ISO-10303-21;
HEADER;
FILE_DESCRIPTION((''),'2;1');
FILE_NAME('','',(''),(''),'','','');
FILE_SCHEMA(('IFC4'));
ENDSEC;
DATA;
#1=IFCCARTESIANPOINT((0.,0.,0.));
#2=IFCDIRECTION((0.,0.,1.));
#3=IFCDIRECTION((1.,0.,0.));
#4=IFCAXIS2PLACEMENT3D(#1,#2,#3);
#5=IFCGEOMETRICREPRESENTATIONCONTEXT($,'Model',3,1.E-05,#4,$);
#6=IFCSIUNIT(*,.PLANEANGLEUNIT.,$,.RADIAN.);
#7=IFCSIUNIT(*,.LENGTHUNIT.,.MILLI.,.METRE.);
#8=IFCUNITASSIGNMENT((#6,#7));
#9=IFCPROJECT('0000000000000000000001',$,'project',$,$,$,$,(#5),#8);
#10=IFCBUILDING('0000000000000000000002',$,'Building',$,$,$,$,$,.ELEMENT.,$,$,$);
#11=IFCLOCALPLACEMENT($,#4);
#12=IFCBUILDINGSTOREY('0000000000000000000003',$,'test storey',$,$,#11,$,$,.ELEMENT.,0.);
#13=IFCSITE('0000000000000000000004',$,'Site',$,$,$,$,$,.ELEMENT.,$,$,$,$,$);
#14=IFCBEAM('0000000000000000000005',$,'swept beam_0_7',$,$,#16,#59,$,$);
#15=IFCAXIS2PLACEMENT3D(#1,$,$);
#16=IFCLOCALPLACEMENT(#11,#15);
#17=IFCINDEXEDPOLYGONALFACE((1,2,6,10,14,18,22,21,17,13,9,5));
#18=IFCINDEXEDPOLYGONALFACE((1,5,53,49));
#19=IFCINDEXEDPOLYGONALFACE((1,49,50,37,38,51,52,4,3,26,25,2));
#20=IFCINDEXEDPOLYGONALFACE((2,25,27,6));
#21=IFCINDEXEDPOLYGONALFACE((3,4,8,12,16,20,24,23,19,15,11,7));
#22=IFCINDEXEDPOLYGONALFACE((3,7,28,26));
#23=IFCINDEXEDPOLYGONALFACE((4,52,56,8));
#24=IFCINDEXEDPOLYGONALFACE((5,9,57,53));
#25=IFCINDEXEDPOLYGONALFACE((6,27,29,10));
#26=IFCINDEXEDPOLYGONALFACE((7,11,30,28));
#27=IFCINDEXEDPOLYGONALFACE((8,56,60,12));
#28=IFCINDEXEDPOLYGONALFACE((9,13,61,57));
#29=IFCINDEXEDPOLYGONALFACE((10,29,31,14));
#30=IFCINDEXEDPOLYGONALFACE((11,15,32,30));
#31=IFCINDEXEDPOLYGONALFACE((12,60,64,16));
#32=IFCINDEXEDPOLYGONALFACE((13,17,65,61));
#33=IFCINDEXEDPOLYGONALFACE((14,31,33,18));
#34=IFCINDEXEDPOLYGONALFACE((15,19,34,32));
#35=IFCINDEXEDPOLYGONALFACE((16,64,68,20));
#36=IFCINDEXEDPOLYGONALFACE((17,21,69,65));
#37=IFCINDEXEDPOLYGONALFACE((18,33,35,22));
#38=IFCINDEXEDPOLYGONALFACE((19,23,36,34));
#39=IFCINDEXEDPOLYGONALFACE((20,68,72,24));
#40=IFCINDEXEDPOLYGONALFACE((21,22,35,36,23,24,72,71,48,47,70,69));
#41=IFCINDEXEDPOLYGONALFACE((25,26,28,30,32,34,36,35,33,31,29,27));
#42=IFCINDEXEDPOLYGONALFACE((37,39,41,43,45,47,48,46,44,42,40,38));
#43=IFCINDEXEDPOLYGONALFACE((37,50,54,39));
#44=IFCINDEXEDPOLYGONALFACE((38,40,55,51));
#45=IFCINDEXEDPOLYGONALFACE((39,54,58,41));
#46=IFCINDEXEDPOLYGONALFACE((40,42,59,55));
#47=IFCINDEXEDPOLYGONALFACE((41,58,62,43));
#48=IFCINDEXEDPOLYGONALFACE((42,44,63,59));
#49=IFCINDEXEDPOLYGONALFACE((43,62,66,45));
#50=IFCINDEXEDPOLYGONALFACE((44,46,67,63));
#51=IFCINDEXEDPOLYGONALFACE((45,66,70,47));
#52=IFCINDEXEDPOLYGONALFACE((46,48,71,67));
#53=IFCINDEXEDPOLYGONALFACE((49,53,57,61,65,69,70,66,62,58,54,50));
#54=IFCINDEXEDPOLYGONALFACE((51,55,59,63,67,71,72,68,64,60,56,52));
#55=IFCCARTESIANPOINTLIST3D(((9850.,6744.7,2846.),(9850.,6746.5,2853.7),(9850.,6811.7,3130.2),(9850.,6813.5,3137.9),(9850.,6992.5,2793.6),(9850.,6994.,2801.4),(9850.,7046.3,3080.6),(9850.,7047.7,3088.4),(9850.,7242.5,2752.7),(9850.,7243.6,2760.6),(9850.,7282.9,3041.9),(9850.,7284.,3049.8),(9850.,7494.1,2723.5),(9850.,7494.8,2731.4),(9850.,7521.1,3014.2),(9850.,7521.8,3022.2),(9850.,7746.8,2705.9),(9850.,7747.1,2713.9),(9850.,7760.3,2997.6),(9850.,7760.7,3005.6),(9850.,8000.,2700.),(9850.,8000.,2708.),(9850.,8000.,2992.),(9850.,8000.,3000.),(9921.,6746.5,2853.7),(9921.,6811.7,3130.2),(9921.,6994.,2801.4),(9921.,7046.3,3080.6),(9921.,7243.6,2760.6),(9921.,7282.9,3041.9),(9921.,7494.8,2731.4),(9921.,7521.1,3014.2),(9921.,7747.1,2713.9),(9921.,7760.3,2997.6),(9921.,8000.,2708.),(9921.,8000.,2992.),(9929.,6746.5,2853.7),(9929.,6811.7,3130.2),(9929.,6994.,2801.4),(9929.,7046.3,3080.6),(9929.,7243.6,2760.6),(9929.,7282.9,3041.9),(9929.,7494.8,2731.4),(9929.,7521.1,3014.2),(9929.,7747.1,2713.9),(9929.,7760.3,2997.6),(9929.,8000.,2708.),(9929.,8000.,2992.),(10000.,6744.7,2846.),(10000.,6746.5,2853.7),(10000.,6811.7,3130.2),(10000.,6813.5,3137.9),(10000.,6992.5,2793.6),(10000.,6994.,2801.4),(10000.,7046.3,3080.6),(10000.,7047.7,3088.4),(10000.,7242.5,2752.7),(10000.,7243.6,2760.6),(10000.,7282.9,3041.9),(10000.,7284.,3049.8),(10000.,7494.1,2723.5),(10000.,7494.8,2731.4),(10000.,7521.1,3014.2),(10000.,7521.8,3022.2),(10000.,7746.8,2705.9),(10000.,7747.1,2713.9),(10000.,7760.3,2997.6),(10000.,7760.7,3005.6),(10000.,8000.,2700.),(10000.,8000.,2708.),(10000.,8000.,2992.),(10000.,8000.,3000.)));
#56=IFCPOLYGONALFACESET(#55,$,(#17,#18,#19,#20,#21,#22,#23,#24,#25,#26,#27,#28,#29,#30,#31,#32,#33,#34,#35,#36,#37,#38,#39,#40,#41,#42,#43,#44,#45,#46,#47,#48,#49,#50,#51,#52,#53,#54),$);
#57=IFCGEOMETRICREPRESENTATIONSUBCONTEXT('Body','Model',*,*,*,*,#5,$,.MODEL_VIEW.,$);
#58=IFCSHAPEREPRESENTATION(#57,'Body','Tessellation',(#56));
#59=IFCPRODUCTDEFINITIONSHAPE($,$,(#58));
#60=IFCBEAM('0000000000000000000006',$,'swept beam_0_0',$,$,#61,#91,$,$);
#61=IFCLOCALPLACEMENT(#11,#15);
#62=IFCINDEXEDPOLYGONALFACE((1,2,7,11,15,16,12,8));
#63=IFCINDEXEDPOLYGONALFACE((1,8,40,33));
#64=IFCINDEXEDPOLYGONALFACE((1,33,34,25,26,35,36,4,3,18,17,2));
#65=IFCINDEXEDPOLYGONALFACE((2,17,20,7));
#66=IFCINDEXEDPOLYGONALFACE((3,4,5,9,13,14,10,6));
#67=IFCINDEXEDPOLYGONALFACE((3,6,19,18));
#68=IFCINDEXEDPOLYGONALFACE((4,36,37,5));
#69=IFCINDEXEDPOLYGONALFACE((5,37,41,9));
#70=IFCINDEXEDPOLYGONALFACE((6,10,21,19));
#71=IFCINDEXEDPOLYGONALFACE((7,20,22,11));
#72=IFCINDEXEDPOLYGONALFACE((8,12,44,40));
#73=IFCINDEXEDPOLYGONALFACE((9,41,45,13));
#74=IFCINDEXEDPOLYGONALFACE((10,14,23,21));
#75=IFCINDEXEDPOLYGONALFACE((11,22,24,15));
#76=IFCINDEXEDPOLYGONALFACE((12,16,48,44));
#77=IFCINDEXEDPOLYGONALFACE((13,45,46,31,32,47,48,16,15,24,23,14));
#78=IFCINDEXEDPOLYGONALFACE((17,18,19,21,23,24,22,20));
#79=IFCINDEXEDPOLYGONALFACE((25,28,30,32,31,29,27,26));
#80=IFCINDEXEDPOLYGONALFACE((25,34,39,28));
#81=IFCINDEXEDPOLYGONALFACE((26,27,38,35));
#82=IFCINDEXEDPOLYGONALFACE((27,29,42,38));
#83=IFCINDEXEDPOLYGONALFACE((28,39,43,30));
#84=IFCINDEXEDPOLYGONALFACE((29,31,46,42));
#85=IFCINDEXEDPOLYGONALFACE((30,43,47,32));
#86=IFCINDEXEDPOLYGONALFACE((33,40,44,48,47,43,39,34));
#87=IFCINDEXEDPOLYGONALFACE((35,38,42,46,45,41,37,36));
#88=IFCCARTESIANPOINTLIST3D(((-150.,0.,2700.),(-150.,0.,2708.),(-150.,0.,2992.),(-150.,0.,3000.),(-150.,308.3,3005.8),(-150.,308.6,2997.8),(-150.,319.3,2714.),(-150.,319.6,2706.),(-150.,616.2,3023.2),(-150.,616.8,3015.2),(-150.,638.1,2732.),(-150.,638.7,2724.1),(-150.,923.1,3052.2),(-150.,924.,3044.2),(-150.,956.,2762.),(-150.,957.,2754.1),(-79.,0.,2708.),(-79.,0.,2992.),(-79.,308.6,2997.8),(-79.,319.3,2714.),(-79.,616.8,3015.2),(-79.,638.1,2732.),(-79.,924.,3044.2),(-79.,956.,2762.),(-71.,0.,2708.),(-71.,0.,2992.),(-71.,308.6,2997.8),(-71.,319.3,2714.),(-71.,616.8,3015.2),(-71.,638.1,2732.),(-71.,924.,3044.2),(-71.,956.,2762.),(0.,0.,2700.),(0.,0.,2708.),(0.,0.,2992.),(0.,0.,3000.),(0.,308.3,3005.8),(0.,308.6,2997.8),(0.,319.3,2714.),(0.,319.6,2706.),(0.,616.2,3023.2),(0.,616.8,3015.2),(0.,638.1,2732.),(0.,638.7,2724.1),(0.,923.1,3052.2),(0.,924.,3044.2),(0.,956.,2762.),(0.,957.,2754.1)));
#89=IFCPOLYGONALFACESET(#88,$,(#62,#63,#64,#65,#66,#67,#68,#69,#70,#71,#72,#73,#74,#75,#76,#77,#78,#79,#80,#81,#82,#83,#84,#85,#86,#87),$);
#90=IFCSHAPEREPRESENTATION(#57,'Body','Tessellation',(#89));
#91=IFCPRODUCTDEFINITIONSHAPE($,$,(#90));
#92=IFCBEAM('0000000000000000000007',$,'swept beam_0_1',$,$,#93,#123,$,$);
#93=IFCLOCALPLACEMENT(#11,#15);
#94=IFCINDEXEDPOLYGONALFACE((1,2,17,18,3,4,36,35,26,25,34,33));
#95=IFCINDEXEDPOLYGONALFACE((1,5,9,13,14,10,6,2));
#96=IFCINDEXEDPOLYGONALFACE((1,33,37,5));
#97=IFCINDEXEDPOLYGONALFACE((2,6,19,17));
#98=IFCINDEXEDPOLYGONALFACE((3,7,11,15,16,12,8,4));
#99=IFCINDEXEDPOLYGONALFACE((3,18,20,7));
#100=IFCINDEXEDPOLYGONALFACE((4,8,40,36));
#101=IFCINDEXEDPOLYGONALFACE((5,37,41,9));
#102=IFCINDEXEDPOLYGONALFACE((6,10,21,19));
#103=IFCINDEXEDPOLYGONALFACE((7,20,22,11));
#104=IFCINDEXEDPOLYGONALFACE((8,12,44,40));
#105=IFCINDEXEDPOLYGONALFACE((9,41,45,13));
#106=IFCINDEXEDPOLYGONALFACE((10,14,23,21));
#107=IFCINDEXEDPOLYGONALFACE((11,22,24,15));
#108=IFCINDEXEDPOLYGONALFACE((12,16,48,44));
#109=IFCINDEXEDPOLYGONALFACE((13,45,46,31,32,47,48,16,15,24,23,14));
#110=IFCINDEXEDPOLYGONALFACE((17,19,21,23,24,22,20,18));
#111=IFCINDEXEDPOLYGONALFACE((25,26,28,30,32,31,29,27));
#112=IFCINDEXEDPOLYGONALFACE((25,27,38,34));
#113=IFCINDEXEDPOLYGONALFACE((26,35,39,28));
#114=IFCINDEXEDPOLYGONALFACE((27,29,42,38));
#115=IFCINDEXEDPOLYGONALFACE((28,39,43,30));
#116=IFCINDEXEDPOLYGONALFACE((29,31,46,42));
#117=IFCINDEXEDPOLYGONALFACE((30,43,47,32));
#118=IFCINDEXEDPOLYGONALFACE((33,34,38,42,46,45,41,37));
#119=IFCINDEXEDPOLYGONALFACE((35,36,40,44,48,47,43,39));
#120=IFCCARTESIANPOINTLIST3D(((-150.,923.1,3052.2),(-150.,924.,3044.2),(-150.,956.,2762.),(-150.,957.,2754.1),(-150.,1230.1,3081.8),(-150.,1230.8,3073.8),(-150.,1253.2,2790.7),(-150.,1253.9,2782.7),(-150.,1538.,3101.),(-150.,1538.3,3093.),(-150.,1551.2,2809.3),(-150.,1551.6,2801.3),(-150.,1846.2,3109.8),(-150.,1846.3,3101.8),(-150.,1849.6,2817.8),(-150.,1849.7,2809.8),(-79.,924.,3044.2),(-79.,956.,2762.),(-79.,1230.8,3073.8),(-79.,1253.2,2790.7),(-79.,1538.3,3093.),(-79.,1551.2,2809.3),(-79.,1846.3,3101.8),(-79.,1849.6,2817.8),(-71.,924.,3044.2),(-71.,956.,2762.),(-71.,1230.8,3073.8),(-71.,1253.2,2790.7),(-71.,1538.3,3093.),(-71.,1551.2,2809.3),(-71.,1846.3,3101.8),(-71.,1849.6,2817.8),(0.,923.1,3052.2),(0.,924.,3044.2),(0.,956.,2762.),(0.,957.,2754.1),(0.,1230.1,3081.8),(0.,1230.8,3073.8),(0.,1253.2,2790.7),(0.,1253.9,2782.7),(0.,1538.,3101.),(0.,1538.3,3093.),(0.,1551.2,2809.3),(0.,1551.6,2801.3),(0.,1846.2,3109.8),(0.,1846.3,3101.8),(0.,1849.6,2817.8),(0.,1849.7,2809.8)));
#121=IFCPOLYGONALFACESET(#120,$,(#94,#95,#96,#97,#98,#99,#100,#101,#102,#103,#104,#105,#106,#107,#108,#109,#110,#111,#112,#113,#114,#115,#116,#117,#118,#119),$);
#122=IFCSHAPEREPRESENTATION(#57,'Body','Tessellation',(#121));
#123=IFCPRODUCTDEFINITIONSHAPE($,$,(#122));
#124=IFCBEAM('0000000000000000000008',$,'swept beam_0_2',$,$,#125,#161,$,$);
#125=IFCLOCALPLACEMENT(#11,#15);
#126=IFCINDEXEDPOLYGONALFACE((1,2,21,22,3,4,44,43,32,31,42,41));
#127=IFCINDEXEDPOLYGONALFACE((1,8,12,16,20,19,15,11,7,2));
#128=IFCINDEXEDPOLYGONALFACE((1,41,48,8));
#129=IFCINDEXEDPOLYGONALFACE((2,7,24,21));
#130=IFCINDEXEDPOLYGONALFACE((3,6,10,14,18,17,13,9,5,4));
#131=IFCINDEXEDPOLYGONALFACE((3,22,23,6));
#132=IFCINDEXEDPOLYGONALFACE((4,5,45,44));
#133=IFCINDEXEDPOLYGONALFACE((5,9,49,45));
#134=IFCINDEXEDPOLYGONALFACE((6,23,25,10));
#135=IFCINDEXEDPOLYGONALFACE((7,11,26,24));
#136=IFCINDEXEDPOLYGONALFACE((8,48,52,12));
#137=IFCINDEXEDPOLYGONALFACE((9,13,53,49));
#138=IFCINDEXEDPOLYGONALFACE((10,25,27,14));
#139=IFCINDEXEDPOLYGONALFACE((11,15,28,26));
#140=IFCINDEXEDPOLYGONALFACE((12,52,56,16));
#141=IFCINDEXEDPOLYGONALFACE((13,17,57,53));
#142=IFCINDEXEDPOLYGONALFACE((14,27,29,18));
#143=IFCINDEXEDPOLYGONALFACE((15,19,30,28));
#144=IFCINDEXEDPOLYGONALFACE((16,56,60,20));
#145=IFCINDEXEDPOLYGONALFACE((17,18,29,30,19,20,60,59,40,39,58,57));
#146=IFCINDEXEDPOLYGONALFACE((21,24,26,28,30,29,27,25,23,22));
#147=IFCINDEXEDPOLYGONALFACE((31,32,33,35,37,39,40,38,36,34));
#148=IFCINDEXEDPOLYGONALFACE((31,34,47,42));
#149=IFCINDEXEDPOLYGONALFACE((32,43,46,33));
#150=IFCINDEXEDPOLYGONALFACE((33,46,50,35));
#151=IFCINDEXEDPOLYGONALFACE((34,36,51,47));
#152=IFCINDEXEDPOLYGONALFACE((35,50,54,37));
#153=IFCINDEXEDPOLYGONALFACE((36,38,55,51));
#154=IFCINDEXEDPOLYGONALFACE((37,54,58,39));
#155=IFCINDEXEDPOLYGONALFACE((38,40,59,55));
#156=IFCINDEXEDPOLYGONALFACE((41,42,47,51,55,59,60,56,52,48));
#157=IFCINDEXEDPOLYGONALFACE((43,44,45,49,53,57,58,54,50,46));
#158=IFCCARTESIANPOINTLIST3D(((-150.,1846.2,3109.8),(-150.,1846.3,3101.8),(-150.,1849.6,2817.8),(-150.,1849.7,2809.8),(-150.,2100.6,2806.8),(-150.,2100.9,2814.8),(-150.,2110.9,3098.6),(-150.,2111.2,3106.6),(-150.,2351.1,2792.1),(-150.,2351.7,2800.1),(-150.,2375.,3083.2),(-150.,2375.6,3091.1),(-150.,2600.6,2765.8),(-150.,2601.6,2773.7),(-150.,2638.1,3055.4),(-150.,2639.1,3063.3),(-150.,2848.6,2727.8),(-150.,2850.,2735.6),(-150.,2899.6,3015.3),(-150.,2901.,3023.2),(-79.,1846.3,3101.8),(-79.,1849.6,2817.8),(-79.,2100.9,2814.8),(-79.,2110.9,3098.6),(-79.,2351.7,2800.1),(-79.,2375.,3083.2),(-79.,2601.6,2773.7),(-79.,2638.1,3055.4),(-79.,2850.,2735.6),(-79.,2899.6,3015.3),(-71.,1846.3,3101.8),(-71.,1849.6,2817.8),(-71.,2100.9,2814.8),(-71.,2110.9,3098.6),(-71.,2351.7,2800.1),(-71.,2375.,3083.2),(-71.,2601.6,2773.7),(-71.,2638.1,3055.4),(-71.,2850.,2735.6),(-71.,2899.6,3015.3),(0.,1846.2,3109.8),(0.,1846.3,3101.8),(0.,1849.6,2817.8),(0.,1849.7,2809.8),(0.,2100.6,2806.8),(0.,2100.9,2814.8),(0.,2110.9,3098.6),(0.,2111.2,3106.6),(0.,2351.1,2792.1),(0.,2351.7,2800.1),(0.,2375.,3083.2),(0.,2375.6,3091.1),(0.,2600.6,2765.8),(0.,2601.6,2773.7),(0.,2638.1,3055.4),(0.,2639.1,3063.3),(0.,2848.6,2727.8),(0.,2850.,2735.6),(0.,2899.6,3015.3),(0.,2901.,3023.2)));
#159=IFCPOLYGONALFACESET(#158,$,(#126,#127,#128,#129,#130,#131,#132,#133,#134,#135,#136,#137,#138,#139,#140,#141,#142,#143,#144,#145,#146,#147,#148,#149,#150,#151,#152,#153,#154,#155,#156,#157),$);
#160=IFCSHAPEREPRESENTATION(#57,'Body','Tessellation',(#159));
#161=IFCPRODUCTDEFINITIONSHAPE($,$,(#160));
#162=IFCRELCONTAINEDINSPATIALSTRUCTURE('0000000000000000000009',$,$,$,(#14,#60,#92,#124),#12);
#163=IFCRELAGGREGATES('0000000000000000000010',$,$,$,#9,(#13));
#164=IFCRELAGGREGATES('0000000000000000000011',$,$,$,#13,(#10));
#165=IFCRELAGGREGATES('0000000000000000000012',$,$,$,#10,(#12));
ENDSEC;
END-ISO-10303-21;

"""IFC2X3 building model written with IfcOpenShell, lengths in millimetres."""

from ifc_helpers import new_model, entity, si_unit, origin_with_axes, place, context, subcontext, project, spatial, element, save


model = new_model("IFC2X3")

# Units and contexts
model_context = context("Model", 3, precision=1e-05, world=origin_with_axes())
body_context = subcontext(model_context, "Body", "Model", "MODEL_VIEW")
ifc_project = project(units=[si_unit("PLANEANGLEUNIT", "RADIAN"), si_unit("LENGTHUNIT", "METRE", prefix="MILLI")], contexts=[model_context])

# Site, building, storey
site = spatial("IfcSite", under=ifc_project, Name="Site", CompositionType="ELEMENT")
building = spatial("IfcBuilding", under=site, Name="Building", CompositionType="ELEMENT")
storey_placement = place(None, origin_with_axes())
storey = spatial("IfcBuildingStorey", under=building, at=storey_placement, Name="test storey", CompositionType="ELEMENT", Elevation=0.0)

# Beams
beam_1_placement = place(storey_placement, origin_with_axes())
element("IfcBeam", 1, at=beam_1_placement, inside=storey, Name="swept beam_0_7", context=body_context, shape_type="SweptSolid", body=[
    entity("IfcRevolvedAreaSolid", entity("IfcArbitraryClosedProfileDef", "AREA", None, entity("IfcPolyline", [entity("IfcCartesianPoint", [292.0, 0.0]), entity("IfcCartesianPoint", [292.0, -71.0]), entity("IfcCartesianPoint", [8.0, -71.0]), entity("IfcCartesianPoint", [8.0, 0.0]), entity("IfcCartesianPoint", [0.0, 0.0]), entity("IfcCartesianPoint", [0.0, -150.0]), entity("IfcCartesianPoint", [8.0, -150.0]), entity("IfcCartesianPoint", [8.0, -79.0]), entity("IfcCartesianPoint", [292.0, -79.0]), entity("IfcCartesianPoint", [292.0, -150.0]), entity("IfcCartesianPoint", [300.0, -150.0]), entity("IfcCartesianPoint", [300.0, 0.0]), entity("IfcCartesianPoint", [292.0, 0.0])])), entity("IfcAxis2Placement3D", entity("IfcCartesianPoint", [10000.0, 6813.5, 3137.9]), entity("IfcDirection", [0.0, -0.9733, 0.2294]), entity("IfcDirection", [0.0, -0.2294, -0.9733])), entity("IfcAxis1Placement", entity("IfcCartesianPoint", [-5171.5, 0.0, 0.0]), entity("IfcDirection", [0.0, 1.0, 0.0])), 0.231492),
])
beam_2_placement = place(storey_placement, origin_with_axes())
element("IfcBeam", 2, at=beam_2_placement, inside=storey, Name="swept beam_0_0", context=body_context, shape_type="SweptSolid", body=[
    entity("IfcRevolvedAreaSolid", entity("IfcArbitraryClosedProfileDef", "AREA", None, entity("IfcPolyline", [entity("IfcCartesianPoint", [292.0, 0.0]), entity("IfcCartesianPoint", [292.0, -71.0]), entity("IfcCartesianPoint", [8.0, -71.0]), entity("IfcCartesianPoint", [8.0, 0.0]), entity("IfcCartesianPoint", [0.0, 0.0]), entity("IfcCartesianPoint", [0.0, -150.0]), entity("IfcCartesianPoint", [8.0, -150.0]), entity("IfcCartesianPoint", [8.0, -79.0]), entity("IfcCartesianPoint", [292.0, -79.0]), entity("IfcCartesianPoint", [292.0, -150.0]), entity("IfcCartesianPoint", [300.0, -150.0]), entity("IfcCartesianPoint", [300.0, 0.0]), entity("IfcCartesianPoint", [292.0, 0.0])])), entity("IfcAxis2Placement3D", entity("IfcCartesianPoint", [0.0, 0.0, 3000.0]), entity("IfcDirection", [0.0, -1.0, 0.0]), entity("IfcDirection", [0.0, 0.0, -1.0])), entity("IfcAxis1Placement", entity("IfcCartesianPoint", [-8191.0, 0.0, 0.0]), entity("IfcDirection", [0.0, 1.0, 0.0])), 0.112942),
])
beam_3_placement = place(storey_placement, origin_with_axes())
element("IfcBeam", 3, at=beam_3_placement, inside=storey, Name="swept beam_0_1", context=body_context, shape_type="SweptSolid", body=[
    entity("IfcRevolvedAreaSolid", entity("IfcArbitraryClosedProfileDef", "AREA", None, entity("IfcPolyline", [entity("IfcCartesianPoint", [-292.0, 0.0]), entity("IfcCartesianPoint", [-292.0, 71.0]), entity("IfcCartesianPoint", [-8.0, 71.0]), entity("IfcCartesianPoint", [-8.0, 0.0]), entity("IfcCartesianPoint", [0.0, 0.0]), entity("IfcCartesianPoint", [0.0, 150.0]), entity("IfcCartesianPoint", [-8.0, 150.0]), entity("IfcCartesianPoint", [-8.0, 79.0]), entity("IfcCartesianPoint", [-292.0, 79.0]), entity("IfcCartesianPoint", [-292.0, 150.0]), entity("IfcCartesianPoint", [-300.0, 150.0]), entity("IfcCartesianPoint", [-300.0, 0.0]), entity("IfcCartesianPoint", [-292.0, 0.0])])), entity("IfcAxis2Placement3D", entity("IfcCartesianPoint", [0.0, 923.1, 3052.2]), entity("IfcDirection", [0.0, -0.9936, -0.1127]), entity("IfcDirection", [0.0, -0.1127, 0.9936])), entity("IfcAxis1Placement", entity("IfcCartesianPoint", [-9131.8, 0.0, 0.0]), entity("IfcDirection", [0.0, 1.0, 0.0])), 0.101327),
])
beam_4_placement = place(storey_placement, origin_with_axes())
element("IfcBeam", 4, at=beam_4_placement, inside=storey, Name="swept beam_0_2", context=body_context, shape_type="SweptSolid", body=[
    entity("IfcRevolvedAreaSolid", entity("IfcArbitraryClosedProfileDef", "AREA", None, entity("IfcPolyline", [entity("IfcCartesianPoint", [-292.0, 0.0]), entity("IfcCartesianPoint", [-292.0, 71.0]), entity("IfcCartesianPoint", [-8.0, 71.0]), entity("IfcCartesianPoint", [-8.0, 0.0]), entity("IfcCartesianPoint", [0.0, 0.0]), entity("IfcCartesianPoint", [0.0, 150.0]), entity("IfcCartesianPoint", [-8.0, 150.0]), entity("IfcCartesianPoint", [-8.0, 79.0]), entity("IfcCartesianPoint", [-292.0, 79.0]), entity("IfcCartesianPoint", [-292.0, 150.0]), entity("IfcCartesianPoint", [-300.0, 150.0]), entity("IfcCartesianPoint", [-300.0, 0.0]), entity("IfcCartesianPoint", [-292.0, 0.0])])), entity("IfcAxis2Placement3D", entity("IfcCartesianPoint", [0.0, 1846.2, 3109.8]), entity("IfcDirection", [0.0, -0.9999, -0.0116]), entity("IfcDirection", [0.0, -0.0116, 0.9999])), entity("IfcAxis1Placement", entity("IfcCartesianPoint", [-5666.8, 0.0, 0.0]), entity("IfcDirection", [0.0, 1.0, 0.0])), 0.187023),
])

save(model, "model.ifc")
